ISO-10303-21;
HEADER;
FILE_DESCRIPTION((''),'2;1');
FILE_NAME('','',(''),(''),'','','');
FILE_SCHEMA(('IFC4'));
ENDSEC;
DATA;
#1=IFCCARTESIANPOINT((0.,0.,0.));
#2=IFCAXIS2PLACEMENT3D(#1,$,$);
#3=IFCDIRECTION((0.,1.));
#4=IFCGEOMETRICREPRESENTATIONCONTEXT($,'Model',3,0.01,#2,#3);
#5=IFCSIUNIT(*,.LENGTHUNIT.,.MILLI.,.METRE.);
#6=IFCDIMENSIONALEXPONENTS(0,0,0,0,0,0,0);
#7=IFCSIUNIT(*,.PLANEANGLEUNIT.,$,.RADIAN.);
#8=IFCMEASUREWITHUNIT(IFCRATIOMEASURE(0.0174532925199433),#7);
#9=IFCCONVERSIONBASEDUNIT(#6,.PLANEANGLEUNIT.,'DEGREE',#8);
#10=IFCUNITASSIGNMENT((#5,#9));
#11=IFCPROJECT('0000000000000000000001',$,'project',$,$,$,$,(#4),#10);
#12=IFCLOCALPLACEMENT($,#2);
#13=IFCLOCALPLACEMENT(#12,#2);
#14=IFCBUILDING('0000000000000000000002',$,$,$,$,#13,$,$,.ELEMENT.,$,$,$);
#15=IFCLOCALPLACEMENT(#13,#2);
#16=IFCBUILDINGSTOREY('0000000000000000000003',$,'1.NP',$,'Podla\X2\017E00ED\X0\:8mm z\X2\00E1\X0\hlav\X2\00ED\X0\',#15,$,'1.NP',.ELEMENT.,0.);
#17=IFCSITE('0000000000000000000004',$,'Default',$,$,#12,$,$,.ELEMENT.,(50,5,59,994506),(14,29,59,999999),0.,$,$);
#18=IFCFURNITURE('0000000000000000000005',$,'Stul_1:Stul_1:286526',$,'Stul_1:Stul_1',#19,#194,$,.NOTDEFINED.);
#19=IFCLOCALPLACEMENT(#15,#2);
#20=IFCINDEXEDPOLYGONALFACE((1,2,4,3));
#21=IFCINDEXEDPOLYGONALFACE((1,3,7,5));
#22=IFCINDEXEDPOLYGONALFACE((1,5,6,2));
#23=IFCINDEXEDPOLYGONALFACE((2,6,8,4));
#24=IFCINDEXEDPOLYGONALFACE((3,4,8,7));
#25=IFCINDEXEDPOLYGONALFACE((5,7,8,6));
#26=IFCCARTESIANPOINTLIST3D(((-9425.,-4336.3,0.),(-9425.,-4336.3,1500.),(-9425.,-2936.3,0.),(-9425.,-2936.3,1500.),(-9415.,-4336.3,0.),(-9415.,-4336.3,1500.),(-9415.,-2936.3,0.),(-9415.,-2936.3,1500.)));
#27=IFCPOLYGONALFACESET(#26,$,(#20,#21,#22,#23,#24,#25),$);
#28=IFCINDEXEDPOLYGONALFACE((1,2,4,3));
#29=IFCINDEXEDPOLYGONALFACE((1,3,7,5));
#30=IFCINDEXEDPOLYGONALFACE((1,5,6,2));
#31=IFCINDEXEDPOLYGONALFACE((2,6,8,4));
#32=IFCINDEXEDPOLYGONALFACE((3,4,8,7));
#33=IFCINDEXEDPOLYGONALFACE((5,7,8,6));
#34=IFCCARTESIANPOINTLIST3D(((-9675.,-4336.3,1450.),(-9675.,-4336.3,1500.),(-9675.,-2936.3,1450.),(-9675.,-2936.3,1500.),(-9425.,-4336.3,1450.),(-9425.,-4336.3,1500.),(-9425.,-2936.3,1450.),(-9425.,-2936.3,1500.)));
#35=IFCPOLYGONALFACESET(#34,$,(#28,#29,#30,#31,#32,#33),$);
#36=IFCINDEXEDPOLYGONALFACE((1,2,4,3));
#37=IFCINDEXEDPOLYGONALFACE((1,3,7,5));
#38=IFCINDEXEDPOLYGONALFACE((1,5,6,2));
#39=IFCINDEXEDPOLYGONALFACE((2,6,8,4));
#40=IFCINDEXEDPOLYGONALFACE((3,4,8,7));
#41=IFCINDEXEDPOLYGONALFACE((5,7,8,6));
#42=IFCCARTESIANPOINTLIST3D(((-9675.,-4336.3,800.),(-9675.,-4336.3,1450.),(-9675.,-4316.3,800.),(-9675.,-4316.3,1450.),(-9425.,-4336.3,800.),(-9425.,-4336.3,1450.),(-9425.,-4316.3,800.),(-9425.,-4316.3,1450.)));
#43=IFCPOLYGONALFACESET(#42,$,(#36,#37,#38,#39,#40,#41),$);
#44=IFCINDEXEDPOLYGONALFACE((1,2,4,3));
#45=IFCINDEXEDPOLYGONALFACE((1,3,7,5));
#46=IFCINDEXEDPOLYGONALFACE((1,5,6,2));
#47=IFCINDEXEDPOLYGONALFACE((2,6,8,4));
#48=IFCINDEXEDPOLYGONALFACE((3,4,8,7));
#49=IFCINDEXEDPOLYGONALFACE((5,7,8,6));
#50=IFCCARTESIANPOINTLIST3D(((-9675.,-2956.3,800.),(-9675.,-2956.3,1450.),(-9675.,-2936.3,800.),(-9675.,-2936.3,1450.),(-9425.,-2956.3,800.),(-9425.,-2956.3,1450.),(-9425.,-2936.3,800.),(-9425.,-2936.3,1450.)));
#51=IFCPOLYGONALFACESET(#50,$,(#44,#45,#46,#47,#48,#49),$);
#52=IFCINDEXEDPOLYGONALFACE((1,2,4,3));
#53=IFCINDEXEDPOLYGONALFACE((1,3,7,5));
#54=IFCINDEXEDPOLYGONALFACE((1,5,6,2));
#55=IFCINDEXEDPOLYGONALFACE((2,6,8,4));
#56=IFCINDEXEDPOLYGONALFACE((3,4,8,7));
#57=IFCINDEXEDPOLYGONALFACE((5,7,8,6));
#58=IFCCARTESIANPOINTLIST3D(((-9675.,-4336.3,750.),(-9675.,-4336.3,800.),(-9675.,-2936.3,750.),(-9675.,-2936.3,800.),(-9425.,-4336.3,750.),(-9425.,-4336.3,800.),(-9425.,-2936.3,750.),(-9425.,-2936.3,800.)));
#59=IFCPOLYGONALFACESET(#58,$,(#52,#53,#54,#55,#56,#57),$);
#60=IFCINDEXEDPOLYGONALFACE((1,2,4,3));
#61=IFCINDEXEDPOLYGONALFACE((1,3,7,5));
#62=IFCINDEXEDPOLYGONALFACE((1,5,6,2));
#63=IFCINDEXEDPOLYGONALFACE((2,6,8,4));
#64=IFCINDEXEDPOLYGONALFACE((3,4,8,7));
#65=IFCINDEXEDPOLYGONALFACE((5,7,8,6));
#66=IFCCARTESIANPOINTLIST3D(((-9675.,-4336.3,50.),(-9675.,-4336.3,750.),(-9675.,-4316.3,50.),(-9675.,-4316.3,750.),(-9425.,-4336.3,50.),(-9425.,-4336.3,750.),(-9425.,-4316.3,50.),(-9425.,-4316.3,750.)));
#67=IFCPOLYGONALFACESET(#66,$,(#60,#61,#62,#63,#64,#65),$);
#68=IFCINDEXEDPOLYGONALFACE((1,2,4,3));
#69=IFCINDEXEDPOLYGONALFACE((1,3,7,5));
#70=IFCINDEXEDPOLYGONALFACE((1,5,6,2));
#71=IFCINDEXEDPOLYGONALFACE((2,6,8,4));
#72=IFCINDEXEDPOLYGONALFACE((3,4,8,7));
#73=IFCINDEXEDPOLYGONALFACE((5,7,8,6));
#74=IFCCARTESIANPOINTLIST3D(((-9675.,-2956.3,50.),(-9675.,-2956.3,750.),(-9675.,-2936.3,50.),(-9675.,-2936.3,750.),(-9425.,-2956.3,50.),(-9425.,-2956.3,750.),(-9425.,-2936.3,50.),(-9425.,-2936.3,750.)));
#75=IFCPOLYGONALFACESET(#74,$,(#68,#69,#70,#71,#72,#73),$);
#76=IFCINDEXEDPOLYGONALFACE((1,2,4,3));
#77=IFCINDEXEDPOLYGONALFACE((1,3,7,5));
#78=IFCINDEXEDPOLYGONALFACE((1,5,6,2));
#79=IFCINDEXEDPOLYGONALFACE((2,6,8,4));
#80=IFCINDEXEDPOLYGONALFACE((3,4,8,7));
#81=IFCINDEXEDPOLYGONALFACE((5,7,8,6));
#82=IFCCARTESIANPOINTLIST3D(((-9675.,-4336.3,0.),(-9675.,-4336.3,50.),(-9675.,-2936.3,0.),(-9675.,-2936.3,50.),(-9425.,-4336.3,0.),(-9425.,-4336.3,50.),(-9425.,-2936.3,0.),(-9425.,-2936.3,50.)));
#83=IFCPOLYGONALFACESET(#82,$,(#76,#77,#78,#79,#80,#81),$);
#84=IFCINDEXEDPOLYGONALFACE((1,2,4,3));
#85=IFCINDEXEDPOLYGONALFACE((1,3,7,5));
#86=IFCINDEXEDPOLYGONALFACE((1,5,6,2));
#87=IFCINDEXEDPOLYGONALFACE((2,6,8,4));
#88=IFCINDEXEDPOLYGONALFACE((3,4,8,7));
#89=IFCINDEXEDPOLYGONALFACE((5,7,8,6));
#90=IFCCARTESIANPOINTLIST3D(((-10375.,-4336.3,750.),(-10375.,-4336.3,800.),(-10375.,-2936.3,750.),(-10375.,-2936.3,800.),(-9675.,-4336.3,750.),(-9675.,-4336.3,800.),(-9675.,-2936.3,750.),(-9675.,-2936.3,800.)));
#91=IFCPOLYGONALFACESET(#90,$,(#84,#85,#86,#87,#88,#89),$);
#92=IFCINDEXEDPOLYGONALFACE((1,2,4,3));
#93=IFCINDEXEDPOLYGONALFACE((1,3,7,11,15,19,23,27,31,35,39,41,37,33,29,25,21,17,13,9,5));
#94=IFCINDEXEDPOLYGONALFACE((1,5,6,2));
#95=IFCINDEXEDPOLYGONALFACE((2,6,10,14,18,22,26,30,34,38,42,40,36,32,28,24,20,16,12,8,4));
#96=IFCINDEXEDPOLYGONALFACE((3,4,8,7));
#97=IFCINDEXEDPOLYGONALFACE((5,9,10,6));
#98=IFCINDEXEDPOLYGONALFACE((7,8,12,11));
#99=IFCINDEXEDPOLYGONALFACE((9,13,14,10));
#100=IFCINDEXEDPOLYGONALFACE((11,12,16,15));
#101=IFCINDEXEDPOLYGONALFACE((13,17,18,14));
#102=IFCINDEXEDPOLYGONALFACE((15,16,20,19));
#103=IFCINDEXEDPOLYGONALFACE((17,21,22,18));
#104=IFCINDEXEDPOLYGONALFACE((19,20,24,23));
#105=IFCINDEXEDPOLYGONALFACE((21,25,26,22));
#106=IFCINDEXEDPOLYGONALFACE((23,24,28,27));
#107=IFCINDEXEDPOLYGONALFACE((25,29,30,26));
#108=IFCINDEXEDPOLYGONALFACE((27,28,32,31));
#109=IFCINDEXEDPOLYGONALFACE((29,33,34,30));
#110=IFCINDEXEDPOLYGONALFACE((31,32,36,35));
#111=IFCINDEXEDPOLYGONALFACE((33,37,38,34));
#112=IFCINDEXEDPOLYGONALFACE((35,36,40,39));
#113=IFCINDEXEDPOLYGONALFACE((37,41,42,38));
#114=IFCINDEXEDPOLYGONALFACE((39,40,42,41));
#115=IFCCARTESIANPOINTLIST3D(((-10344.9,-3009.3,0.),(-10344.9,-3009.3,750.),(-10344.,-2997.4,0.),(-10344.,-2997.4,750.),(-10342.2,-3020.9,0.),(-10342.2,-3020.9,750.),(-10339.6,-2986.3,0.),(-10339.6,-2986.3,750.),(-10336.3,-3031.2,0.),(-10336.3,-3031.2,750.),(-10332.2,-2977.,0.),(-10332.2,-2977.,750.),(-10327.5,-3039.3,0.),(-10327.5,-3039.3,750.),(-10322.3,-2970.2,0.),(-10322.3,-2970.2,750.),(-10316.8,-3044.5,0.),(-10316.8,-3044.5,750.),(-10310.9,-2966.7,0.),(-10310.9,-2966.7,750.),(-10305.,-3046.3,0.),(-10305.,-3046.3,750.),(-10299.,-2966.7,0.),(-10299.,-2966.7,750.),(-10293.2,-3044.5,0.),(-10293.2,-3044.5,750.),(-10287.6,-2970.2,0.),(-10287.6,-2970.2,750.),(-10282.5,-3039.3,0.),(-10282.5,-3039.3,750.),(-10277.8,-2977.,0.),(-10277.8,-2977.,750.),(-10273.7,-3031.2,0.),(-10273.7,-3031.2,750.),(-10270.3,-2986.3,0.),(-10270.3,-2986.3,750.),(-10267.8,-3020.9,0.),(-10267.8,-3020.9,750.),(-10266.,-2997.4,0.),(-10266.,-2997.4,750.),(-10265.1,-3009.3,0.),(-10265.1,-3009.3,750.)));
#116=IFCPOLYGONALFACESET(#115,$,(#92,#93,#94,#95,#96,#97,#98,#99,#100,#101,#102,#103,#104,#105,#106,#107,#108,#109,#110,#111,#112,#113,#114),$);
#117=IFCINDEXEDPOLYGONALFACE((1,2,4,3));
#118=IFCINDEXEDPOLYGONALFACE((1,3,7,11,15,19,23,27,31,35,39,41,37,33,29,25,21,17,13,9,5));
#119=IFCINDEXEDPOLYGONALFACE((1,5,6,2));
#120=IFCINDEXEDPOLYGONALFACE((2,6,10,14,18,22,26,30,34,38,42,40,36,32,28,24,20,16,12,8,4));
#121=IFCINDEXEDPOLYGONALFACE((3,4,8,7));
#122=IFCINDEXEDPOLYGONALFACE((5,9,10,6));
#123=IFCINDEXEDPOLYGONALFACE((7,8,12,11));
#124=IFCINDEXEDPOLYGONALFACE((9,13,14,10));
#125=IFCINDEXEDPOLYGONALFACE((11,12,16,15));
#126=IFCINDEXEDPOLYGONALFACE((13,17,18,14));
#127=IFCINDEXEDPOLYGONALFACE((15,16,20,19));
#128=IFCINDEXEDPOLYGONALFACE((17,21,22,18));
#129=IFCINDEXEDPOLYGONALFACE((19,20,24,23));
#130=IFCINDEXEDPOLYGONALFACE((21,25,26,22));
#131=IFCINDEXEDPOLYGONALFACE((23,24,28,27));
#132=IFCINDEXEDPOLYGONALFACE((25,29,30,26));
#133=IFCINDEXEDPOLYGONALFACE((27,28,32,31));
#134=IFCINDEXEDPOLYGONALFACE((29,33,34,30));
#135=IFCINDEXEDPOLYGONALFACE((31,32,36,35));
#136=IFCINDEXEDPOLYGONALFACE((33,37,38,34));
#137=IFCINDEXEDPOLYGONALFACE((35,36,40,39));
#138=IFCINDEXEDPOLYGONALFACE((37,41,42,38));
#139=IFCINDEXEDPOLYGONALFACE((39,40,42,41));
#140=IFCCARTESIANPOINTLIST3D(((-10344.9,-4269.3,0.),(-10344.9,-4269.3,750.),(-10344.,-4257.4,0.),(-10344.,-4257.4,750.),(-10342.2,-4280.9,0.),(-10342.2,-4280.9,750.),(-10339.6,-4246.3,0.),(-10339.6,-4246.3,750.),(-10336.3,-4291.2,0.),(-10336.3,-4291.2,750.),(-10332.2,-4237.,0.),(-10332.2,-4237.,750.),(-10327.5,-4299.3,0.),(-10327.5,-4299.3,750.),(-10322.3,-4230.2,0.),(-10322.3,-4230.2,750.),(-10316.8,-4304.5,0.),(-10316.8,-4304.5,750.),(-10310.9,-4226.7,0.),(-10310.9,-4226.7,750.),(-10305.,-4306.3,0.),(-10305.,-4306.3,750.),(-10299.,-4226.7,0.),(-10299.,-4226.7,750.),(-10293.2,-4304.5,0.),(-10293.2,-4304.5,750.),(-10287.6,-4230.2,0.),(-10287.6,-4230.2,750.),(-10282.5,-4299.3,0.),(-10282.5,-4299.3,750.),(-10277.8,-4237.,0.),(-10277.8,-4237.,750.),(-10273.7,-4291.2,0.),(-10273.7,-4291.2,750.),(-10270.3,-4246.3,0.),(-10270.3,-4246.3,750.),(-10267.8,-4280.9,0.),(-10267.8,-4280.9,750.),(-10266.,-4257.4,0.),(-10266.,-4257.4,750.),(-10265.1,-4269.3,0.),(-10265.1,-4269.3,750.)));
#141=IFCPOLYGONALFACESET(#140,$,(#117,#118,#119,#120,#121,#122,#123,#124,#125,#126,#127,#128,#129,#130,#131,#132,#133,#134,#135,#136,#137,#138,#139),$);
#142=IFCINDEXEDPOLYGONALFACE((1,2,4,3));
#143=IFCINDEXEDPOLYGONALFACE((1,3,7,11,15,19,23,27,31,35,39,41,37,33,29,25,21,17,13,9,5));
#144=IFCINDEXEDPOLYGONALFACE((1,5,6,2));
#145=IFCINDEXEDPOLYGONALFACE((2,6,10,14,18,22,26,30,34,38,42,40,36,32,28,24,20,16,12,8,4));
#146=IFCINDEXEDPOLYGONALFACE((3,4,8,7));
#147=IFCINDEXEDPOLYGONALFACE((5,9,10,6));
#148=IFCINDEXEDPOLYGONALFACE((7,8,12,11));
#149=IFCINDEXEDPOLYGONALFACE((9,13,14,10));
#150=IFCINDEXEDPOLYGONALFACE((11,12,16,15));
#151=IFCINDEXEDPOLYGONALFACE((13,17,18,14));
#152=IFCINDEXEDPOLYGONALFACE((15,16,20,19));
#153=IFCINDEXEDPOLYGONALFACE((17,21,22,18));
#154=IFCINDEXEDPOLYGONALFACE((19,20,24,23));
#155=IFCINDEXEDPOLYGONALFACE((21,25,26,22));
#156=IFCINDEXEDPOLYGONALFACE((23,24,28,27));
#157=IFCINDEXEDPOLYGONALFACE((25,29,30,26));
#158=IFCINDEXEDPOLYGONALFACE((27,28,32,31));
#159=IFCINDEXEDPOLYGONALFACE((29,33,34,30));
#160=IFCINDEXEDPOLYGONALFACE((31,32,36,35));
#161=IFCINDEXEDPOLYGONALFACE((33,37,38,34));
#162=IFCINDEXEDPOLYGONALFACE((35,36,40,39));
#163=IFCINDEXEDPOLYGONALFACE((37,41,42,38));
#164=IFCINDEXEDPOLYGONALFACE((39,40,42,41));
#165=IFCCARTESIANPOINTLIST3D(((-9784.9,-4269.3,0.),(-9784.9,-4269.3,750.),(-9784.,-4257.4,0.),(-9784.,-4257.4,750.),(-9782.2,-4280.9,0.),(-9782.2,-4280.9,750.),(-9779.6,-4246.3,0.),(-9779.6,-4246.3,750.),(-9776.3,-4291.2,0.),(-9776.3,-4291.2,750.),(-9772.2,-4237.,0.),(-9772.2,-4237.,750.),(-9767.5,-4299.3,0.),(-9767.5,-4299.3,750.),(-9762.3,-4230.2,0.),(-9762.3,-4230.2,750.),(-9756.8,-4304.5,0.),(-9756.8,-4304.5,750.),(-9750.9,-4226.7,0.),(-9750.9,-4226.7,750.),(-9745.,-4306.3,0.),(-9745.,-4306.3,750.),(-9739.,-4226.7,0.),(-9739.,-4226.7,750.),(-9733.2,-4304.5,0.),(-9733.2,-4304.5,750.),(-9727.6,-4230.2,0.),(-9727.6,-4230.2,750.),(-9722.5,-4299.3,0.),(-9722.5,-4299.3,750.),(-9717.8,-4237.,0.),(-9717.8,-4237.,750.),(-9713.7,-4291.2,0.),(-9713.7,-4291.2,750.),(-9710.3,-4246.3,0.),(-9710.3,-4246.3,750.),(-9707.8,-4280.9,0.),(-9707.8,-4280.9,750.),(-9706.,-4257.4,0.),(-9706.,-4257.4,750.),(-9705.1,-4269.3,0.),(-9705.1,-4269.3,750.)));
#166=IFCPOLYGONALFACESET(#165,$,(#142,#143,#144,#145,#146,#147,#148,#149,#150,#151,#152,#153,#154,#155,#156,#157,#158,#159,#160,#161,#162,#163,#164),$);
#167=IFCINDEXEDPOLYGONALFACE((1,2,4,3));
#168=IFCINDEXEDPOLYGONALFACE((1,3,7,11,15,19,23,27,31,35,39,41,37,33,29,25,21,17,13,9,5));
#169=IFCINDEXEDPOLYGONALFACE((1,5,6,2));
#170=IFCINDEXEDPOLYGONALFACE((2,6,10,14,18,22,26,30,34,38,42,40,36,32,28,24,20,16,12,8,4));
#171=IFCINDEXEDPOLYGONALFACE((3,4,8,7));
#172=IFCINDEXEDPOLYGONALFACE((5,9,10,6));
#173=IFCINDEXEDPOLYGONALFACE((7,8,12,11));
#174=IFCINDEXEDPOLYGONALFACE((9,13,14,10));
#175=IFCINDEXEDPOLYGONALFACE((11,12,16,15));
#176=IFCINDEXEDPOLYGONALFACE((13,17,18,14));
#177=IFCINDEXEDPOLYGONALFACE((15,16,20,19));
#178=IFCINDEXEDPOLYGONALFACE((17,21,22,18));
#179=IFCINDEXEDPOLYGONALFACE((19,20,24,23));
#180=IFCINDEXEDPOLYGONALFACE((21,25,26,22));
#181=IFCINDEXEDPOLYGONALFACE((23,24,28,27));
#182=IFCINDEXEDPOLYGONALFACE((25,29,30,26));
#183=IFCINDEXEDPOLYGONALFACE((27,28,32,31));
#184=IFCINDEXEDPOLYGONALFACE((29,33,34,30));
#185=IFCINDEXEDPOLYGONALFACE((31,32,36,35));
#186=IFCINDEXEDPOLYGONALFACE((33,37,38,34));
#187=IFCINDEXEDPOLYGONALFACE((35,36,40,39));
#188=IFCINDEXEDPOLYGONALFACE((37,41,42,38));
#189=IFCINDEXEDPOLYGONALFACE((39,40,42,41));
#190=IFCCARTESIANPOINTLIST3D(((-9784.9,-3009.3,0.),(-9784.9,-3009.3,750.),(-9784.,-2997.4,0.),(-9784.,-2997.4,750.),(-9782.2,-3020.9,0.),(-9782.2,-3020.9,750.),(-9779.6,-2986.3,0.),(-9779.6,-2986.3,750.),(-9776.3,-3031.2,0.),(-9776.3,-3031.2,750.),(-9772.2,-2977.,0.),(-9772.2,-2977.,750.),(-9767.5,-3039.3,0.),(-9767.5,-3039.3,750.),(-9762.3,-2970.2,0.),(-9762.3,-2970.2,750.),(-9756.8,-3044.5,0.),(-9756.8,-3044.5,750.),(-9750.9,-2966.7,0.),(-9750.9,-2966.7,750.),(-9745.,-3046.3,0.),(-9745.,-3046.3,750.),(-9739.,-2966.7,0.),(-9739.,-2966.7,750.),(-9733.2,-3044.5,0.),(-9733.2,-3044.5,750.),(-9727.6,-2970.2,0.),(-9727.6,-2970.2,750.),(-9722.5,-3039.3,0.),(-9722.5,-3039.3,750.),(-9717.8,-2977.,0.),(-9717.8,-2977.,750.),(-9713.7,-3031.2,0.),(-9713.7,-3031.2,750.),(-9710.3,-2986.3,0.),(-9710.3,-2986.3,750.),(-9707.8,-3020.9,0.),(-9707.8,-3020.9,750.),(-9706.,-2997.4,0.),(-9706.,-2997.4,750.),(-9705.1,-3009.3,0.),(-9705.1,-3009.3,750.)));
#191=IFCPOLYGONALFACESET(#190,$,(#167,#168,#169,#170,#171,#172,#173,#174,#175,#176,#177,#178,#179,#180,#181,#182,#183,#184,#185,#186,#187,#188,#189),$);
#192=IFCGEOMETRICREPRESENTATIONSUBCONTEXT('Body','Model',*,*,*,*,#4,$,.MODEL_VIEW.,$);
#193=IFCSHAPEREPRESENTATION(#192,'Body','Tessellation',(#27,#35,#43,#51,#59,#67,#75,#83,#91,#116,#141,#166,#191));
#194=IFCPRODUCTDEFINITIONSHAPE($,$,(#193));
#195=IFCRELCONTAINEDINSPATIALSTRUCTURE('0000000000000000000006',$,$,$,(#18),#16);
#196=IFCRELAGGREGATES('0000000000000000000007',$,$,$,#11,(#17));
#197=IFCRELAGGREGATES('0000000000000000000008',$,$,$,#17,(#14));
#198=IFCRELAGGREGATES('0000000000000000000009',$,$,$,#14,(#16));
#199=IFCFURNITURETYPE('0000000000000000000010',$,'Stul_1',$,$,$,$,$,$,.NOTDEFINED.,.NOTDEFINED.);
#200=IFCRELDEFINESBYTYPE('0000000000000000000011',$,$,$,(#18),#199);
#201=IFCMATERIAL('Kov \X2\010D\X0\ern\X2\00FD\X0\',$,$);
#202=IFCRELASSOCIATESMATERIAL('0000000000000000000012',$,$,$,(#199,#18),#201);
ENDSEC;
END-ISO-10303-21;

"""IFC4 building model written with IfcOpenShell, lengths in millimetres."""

from ifc_helpers import new_model, entity, si_unit, converted_unit, direction, frame, frame_2d, origin, origin_2d_with_axis, place, context, subcontext, project, spatial, rectangle, circle, extrude, source, transform, mapped, material, type_object, type_shapes, element, save


model = new_model("IFC4")

# Units and contexts
model_context = context("Model", 3, precision=0.01, world=origin(), true_north=direction((0.0, 1.0)))
body_context = subcontext(model_context, "Body", "Model", "MODEL_VIEW")
ifc_project = project(units=[si_unit("LENGTHUNIT", "METRE", prefix="MILLI"), converted_unit("PLANEANGLEUNIT", "DEGREE", entity("IfcRatioMeasure", 0.0174532925199433), si_unit("PLANEANGLEUNIT", "RADIAN"), dimensions=[0, 0, 0, 0, 0, 0, 0])], contexts=[model_context])

# Site, building, storey
site_placement = place(None, origin())
site = spatial("IfcSite", under=ifc_project, at=site_placement, Name="Default", CompositionType="ELEMENT", RefLatitude=(50, 5, 59, 994506), RefLongitude=(14, 29, 59, 999999), RefElevation=0.0)
building_placement = place(site_placement, origin())
building = spatial("IfcBuilding", under=site, at=building_placement, CompositionType="ELEMENT")
storey_placement = place(building_placement, origin())
storey = spatial("IfcBuildingStorey", under=building, at=storey_placement, Name="1.NP", ObjectType="Podlaží:8mm záhlaví", LongName="1.NP", CompositionType="ELEMENT", Elevation=0.0)

# Furniture
ifc_material_1 = material(Name="Kov černý")
furniture_type = type_object("IfcFurnitureType", Name="Stul_1", AssemblyPlace="NOTDEFINED", PredefinedType="NOTDEFINED", material=ifc_material_1)
shared_shape_1 = source(origin(), body_context, "Body", "SweptSolid", [
    extrude(rectangle(XDim=1400.0, YDim=10.0, at=origin_2d_with_axis()), frame((0.0, 605.0, 0.0), z_axis=(0.0, 0.0, 1.0), x_axis=(-1.0, 0.0, 0.0)), (0.0, 0.0, 1.0), 1500.0),
    extrude(rectangle(XDim=1400.0, YDim=250.0, at=frame_2d((0.0, 0.0), x_axis=(1.0, 0.0))), frame((0.0, 475.0, 1450.0), z_axis=(0.0, 0.0, 1.0), x_axis=(-1.0, 0.0, 0.0)), (0.0, 0.0, 1.0), 50.0),
    extrude(rectangle(XDim=20.0, YDim=250.0, at=origin_2d_with_axis()), frame((690.0, 475.0, 800.0), z_axis=(0.0, 0.0, 1.0), x_axis=(-1.0, 0.0, 0.0)), (0.0, 0.0, 1.0), 650.0),
    extrude(rectangle(XDim=20.0, YDim=250.0, at=frame_2d((0.0, 0.0), x_axis=(1.0, 0.0))), frame((-690.0, 475.0, 800.0), z_axis=(0.0, 0.0, 1.0), x_axis=(-1.0, 0.0, 0.0)), (0.0, 0.0, 1.0), 650.0),
    extrude(rectangle(XDim=1400.0, YDim=250.0, at=origin_2d_with_axis()), frame((0.0, 475.0, 750.0), z_axis=(0.0, 0.0, 1.0), x_axis=(-1.0, 0.0, 0.0)), (0.0, 0.0, 1.0), 50.0),
    extrude(rectangle(XDim=20.0, YDim=250.0, at=origin_2d_with_axis()), frame((690.0, 475.0, 50.0), z_axis=(0.0, 0.0, 1.0), x_axis=(-1.0, 0.0, 0.0)), (0.0, 0.0, 1.0), 700.0),
    extrude(rectangle(XDim=20.0, YDim=250.0, at=frame_2d((0.0, 0.0), x_axis=(1.0, 0.0))), frame((-690.0, 475.0, 50.0), z_axis=(0.0, 0.0, 1.0), x_axis=(-1.0, 0.0, 0.0)), (0.0, 0.0, 1.0), 700.0),
    extrude(rectangle(XDim=1400.0, YDim=250.0, at=origin_2d_with_axis()), frame((0.0, 475.0, 0.0), z_axis=(0.0, 0.0, 1.0), x_axis=(-1.0, 0.0, 0.0)), (0.0, 0.0, 1.0), 50.0),
    extrude(rectangle(XDim=1400.0, YDim=700.0, at=origin_2d_with_axis()), frame((0.0, 0.0, 750.0), z_axis=(0.0, 0.0, 1.0), x_axis=(-1.0, 0.0, 0.0)), (0.0, 0.0, 1.0), 50.0),
    extrude(circle(Radius=40.0, at=frame_2d((0.0, 0.0), x_axis=(1.0, 0.0))), frame((-630.0, -280.0, 0.0)), (0.0, 0.0, 1.0), 750.0),
    extrude(circle(Radius=40.0, at=frame_2d((0.0, 0.0), x_axis=(1.0, 0.0))), frame((630.0, -280.0, 0.0)), (0.0, 0.0, 1.0), 750.0),
    extrude(circle(Radius=40.0, at=frame_2d((0.0, 0.0), x_axis=(1.0, 0.0))), frame((630.0, 280.0, 0.0)), (0.0, 0.0, 1.0), 750.0),
    extrude(circle(Radius=40.0, at=frame_2d((0.0, 0.0), x_axis=(1.0, 0.0))), frame((-630.0, 280.0, 0.0)), (0.0, 0.0, 1.0), 750.0),
])
type_shapes(furniture_type, [shared_shape_1])
for number, where, z_axis, x_axis, name in (
    (1, (-10025.0, -3636.3, 0.0), (0.0, 0.0, 1.0), (0.0, -1.0, 0.0), "Stul_1:Stul_1:286526"),
):
    element("IfcFurniture", number, at=place(storey_placement, frame(where, z_axis=z_axis, x_axis=x_axis)), inside=storey, type_object=furniture_type, material=ifc_material_1, Name=name, ObjectType="Stul_1:Stul_1", PredefinedType="NOTDEFINED", context=body_context, shape_type="MappedRepresentation", body=[
        mapped(shared_shape_1, transform((0.0, 0.0, 0.0), scale=1.0)),
    ])

save(model, "model.ifc")
